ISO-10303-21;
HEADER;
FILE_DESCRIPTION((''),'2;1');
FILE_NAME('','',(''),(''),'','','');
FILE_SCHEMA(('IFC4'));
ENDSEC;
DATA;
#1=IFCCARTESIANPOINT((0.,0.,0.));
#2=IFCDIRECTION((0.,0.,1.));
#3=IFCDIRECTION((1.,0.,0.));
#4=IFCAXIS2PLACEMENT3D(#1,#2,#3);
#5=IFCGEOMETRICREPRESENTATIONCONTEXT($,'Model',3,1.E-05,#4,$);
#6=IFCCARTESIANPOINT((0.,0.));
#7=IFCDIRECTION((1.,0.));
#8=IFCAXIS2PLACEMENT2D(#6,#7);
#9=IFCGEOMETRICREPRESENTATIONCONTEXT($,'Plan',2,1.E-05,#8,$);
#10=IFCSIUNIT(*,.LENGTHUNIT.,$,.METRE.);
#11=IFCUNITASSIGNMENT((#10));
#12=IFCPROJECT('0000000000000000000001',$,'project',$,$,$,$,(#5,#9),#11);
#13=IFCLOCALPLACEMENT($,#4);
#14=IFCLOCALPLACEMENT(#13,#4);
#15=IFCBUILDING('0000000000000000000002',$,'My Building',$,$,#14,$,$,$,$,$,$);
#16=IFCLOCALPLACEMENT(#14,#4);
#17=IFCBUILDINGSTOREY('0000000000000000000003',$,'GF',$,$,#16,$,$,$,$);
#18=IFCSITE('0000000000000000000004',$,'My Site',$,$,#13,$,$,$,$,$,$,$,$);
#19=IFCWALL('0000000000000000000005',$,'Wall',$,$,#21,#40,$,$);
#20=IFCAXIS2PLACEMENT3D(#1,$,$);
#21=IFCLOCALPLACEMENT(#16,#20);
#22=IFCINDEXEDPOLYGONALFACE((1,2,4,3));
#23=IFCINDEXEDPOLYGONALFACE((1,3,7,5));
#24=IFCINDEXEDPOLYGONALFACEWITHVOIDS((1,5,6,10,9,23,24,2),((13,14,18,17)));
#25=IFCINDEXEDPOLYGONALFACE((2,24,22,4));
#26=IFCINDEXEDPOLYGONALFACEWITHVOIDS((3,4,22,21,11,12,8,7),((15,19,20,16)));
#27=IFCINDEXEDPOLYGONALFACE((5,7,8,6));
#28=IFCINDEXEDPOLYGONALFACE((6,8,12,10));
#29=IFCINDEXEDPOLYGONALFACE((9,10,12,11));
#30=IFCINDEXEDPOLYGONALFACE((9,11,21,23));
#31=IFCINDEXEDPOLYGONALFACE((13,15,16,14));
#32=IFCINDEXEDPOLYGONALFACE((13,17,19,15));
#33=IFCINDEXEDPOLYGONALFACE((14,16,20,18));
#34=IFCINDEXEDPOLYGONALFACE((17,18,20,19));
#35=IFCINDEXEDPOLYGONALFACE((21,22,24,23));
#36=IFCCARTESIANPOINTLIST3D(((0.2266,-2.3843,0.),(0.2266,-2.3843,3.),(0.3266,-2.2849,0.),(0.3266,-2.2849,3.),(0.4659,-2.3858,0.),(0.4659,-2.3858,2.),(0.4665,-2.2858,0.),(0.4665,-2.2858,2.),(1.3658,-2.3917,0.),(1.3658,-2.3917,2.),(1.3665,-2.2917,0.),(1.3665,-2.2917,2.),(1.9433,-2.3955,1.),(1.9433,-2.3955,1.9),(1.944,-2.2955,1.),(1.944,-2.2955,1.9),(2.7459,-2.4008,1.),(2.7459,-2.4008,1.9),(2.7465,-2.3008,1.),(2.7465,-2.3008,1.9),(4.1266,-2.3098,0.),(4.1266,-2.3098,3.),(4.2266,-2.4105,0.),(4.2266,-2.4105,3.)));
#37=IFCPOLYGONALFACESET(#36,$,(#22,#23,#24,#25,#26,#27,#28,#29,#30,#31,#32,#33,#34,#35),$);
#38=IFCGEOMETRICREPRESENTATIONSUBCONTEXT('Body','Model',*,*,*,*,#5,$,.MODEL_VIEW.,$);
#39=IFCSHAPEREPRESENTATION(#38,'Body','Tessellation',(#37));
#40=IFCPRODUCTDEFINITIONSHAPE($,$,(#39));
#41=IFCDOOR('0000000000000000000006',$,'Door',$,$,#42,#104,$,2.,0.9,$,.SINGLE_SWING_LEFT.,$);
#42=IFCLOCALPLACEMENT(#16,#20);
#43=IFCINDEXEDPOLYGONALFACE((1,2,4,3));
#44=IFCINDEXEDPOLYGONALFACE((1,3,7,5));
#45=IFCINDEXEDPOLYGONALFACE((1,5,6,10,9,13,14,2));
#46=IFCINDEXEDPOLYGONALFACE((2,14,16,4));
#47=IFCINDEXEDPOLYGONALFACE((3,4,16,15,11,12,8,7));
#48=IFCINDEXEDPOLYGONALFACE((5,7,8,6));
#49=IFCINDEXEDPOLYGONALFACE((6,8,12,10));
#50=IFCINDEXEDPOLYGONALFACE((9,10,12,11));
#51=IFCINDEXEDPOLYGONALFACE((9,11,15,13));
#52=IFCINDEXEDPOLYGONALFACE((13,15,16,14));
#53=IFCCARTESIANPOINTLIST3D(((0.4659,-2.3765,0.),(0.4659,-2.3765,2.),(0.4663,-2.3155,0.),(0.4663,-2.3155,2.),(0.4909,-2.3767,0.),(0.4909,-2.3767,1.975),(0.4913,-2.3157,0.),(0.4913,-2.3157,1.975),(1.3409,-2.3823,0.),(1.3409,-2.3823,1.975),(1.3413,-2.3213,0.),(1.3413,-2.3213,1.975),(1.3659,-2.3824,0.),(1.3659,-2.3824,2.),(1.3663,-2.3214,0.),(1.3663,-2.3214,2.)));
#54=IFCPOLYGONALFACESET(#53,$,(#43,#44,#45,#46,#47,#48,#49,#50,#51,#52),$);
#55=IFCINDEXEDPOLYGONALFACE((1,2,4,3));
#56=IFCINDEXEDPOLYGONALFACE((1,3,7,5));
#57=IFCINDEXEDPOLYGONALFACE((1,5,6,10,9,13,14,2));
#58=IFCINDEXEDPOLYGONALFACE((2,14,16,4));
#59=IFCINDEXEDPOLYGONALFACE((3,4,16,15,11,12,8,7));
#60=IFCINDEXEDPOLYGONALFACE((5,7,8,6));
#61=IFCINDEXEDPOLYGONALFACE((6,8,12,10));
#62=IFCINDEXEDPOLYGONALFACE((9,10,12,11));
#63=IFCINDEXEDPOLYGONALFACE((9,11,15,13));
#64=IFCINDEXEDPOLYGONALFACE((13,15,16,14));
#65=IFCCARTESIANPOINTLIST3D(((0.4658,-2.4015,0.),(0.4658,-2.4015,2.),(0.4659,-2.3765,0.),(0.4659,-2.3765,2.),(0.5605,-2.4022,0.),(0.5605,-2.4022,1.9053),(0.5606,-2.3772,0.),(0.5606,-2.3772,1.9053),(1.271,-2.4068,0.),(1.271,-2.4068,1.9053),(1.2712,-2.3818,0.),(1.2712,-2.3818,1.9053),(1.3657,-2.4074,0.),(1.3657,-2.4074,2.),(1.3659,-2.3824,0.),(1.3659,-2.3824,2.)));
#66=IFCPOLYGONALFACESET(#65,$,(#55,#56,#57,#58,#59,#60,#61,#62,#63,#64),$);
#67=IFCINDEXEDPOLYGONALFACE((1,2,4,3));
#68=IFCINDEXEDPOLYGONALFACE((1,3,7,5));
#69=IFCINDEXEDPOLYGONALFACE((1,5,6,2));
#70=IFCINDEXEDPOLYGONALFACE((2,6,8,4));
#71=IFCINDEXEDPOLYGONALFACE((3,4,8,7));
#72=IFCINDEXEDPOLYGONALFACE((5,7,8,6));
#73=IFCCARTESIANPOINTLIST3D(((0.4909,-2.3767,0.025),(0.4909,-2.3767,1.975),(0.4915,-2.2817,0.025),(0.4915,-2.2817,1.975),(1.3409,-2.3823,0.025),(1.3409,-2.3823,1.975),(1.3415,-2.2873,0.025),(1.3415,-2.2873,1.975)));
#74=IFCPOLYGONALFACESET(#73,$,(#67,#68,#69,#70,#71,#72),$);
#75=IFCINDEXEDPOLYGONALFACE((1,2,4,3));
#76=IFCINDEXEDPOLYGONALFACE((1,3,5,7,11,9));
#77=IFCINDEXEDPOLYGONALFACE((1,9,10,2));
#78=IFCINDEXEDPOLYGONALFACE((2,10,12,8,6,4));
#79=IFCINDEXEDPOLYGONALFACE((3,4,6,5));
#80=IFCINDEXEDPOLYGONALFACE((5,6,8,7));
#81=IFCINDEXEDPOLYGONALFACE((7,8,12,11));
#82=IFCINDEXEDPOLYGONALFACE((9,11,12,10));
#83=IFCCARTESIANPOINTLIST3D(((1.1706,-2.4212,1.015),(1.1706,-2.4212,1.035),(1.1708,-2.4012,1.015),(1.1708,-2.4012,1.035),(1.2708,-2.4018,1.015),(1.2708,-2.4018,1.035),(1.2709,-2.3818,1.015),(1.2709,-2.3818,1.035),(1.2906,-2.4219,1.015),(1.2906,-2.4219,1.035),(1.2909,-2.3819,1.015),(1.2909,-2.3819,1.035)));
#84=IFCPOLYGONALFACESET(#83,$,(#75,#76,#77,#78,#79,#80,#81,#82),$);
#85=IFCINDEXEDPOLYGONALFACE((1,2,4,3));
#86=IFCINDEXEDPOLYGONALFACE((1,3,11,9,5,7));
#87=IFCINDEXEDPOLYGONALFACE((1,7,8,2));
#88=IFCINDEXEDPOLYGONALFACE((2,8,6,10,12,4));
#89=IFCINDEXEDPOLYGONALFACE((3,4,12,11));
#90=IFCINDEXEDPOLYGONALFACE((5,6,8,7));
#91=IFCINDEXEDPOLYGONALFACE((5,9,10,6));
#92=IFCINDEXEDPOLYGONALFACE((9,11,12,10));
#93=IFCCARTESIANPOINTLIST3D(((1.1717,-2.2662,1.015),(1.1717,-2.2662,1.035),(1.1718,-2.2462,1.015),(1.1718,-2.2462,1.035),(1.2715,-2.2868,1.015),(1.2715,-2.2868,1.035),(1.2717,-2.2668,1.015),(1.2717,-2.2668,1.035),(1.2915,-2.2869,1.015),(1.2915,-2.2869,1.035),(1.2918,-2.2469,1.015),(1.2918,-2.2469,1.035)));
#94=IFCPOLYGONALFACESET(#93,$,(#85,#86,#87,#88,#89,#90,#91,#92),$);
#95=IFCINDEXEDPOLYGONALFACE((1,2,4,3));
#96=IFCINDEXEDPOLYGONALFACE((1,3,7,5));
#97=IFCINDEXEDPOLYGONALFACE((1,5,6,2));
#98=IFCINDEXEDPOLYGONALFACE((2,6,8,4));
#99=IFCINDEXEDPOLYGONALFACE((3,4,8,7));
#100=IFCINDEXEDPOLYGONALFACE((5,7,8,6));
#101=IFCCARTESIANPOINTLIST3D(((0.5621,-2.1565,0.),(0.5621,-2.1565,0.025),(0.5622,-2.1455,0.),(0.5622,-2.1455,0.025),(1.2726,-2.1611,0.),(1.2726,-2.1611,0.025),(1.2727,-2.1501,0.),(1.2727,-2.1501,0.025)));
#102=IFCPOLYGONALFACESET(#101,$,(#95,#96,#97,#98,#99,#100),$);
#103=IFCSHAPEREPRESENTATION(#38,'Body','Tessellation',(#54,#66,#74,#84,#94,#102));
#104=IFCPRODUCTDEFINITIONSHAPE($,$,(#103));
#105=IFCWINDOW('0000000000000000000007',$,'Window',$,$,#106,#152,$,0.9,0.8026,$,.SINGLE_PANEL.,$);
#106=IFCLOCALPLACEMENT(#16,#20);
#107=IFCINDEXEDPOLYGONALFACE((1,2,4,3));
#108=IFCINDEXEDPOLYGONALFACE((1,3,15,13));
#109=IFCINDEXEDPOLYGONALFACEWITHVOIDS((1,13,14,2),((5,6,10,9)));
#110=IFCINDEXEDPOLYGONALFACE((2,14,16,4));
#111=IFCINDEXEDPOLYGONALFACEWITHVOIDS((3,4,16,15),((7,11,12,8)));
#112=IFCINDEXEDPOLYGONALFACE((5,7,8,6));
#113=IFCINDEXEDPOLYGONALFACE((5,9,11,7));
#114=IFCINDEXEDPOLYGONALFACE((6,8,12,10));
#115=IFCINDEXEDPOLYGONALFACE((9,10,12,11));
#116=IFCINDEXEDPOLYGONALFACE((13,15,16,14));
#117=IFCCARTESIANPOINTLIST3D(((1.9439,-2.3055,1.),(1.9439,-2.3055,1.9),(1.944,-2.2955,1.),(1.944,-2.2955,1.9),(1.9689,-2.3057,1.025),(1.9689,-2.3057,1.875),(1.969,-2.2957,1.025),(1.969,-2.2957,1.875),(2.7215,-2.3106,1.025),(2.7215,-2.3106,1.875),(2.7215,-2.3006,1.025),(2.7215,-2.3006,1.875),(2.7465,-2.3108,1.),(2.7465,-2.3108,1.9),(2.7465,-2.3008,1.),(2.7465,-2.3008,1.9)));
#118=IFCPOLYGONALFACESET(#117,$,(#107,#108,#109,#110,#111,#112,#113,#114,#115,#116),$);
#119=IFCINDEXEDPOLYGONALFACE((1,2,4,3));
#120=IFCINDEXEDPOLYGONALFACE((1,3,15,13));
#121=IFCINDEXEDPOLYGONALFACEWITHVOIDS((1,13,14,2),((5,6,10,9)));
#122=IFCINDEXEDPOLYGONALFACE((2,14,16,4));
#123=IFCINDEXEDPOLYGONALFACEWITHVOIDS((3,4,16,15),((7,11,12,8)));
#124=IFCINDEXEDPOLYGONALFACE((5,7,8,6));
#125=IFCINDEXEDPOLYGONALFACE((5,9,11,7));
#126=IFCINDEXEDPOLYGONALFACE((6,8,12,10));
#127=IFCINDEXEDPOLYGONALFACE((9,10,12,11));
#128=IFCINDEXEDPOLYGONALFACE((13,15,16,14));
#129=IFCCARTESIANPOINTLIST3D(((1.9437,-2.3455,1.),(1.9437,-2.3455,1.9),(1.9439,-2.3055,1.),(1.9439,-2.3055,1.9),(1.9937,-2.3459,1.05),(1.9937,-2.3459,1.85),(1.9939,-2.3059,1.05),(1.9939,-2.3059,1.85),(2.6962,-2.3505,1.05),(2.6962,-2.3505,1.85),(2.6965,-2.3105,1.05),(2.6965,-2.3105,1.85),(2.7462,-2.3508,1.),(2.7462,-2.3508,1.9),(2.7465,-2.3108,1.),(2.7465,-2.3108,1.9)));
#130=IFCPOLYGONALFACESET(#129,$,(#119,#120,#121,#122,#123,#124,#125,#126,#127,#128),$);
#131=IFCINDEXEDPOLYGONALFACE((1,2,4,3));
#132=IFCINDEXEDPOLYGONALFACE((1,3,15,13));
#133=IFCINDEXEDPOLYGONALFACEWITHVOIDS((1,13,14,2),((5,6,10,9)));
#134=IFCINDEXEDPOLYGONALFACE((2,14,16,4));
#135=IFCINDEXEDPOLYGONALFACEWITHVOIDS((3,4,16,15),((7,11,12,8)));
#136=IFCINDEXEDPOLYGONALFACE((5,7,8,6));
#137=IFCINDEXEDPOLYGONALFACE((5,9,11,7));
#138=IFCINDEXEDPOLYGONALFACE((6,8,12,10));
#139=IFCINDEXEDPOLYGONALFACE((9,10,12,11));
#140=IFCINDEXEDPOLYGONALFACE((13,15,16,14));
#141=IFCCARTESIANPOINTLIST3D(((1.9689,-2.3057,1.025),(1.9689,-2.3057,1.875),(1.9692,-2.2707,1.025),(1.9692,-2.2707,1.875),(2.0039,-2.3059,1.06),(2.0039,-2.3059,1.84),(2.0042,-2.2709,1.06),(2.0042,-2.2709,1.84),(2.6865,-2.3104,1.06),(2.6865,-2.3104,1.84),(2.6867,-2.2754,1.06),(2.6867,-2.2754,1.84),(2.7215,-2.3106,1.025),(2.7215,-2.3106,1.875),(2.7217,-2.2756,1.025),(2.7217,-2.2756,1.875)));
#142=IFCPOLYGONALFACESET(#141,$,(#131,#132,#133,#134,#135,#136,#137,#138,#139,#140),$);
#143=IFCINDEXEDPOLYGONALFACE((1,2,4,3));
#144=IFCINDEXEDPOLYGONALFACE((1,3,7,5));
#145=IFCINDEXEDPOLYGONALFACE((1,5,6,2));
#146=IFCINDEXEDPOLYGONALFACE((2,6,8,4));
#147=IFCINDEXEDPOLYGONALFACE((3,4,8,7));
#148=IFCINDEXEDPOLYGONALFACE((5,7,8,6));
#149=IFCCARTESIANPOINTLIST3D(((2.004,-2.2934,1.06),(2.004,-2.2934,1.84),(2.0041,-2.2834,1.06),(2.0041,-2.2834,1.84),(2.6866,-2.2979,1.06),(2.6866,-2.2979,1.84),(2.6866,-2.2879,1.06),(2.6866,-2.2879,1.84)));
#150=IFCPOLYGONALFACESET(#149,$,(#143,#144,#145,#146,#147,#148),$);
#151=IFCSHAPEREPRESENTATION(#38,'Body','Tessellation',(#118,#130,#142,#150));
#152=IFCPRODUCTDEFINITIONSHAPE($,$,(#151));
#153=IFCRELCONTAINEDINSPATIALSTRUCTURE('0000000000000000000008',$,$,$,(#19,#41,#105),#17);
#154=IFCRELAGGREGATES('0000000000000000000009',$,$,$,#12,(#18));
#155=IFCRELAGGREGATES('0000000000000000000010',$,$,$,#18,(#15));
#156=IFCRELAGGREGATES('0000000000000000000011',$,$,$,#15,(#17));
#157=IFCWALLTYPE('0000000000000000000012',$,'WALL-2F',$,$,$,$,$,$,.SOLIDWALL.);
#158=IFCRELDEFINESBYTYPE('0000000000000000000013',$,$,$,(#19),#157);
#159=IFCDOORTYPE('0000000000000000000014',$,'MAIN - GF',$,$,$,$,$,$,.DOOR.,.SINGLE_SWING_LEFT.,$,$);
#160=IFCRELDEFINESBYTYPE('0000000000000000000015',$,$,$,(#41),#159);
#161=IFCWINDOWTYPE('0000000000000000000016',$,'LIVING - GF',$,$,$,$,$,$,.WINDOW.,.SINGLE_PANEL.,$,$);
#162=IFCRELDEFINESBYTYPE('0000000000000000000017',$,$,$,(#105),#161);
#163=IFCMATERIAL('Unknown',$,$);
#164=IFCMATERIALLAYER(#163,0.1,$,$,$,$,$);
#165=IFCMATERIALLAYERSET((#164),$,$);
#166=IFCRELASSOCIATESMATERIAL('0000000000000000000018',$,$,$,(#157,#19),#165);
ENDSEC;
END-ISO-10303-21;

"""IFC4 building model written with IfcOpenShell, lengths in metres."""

from ifc_helpers import new_model, entity, si_unit, frame, origin_with_axes, origin_2d_with_axis, place, context, subcontext, project, spatial, line, indexed_curve, outline, extrude, shape, source, transform, mapped, material, layer, layer_set, layer_usage, type_object, type_shapes, element, fill, save


model = new_model("IFC4")

# Units and contexts
model_context = context("Model", 3, precision=1e-05, world=origin_with_axes())
plan_context = context("Plan", 2, precision=1e-05, world=origin_2d_with_axis())
body_context_1 = subcontext(model_context, "Body", "Model", "MODEL_VIEW")
body_context_2 = subcontext(plan_context, "Body", "Plan", "PLAN_VIEW")
ifc_project = project(units=[si_unit("LENGTHUNIT", "METRE")], contexts=[model_context, plan_context])

# Site, building, storey
site_placement = place(None, origin_with_axes())
site = spatial("IfcSite", under=ifc_project, at=site_placement, Name="My Site")
building_placement = place(site_placement, origin_with_axes())
building = spatial("IfcBuilding", under=site, at=building_placement, Name="My Building")
storey_placement = place(building_placement, origin_with_axes())
storey = spatial("IfcBuildingStorey", under=building, at=storey_placement, Name="GF")

# Shared definitions
ifc_material = material(Name="Unknown")

# Shared definitions
ifc_layer_1 = layer(ifc_material, 0.1)
ifc_layer_set_1 = layer_set([ifc_layer_1])
wall_type_1 = type_object("IfcWallType", Name="WALL-2F", PredefinedType="SOLIDWALL", material=ifc_layer_set_1)

# Wall, openings, door, window
ifc_layer_usage_1 = layer_usage(ifc_layer_set_1, "AXIS2", "POSITIVE", 0.0)
wall_1_placement = place(storey_placement, frame((0.2266, -2.3843, 0.0), z_axis=(0.0, 0.0, 1.0), x_axis=(0.999979, -0.006552, 0.0)))
wall_1 = element("IfcWall", 1, at=wall_1_placement, inside=storey, type_object=wall_type_1, material=ifc_layer_usage_1, Name="Wall", context=body_context_1, shape_type="SweptSolid", body=[
    extrude(outline(indexed_curve([(0.0, 0.0), (0.0993, 0.1), (3.8994, 0.1), (4.0001, 0.0)], segments=[line(1, 2, 3, 4, 1)])), origin_with_axes(), (0.0, 0.0, 1.0), 3.0),
])
shared_shape_1 = source(origin_with_axes(), body_context_1, "Body", "SweptSolid", [
    extrude(outline(indexed_curve([(0.0, 0.0), (0.9, 0.0), (0.9, 2.0), (0.0, 2.0)], segments=[line(1, 2, 3, 4, 1)])), frame((0.0, -0.6, 0.0), z_axis=(0.0, -1.0, 0.0), x_axis=(1.0, 0.0, 0.0)), (0.0, 0.0, -1.0), 1.2),
])
opening_1_placement = place(wall_1_placement, frame((0.2393, 0.0, 0.0), z_axis=(0.0, 0.0, 1.0), x_axis=(1.0, 0.0, 0.0)))
opening_1 = element("IfcOpeningElement", 2, at=opening_1_placement, cuts=wall_1, PredefinedType="OPENING", context=body_context_1, shape_type="MappedRepresentation", body=[
    mapped(shared_shape_1, transform((0.0, 0.0, 0.0), x_axis=(1.0, 0.0, 0.0), y_axis=(0.0, 1.0, 0.0), z_axis=(0.0, 0.0, 1.0), scale=1.0)),
])
shared_shape_2 = source(origin_with_axes(), body_context_1, "Body", "SweptSolid", [
    extrude(outline(indexed_curve([(0.0, 0.0), (0.8026, 0.0), (0.8026, 0.9), (0.0, 0.9)], segments=[line(1, 2, 3, 4, 1)])), frame((0.0, -0.6, 0.0), z_axis=(0.0, -1.0, 0.0), x_axis=(1.0, 0.0, 0.0)), (0.0, 0.0, -1.0), 1.2),
])
opening_2_placement = place(wall_1_placement, frame((1.7168, 0.0, 1.0), z_axis=(0.0, 0.0, 1.0), x_axis=(1.0, 0.0, 0.0)))
opening_2 = element("IfcOpeningElement", 3, at=opening_2_placement, cuts=wall_1, PredefinedType="OPENING", context=body_context_1, shape_type="MappedRepresentation", body=[
    mapped(shared_shape_2, transform((0.0, 0.0, 0.0), x_axis=(1.0, 0.0, 0.0), y_axis=(0.0, 1.0, 0.0), z_axis=(0.0, 0.0, 1.0), scale=1.0)),
])
door_type_1 = type_object("IfcDoorType", Name="MAIN - GF", OperationType="SINGLE_SWING_LEFT", PredefinedType="DOOR")
shared_shape_3 = source(origin_with_axes(), body_context_1, "Body", "SweptSolid", [
    extrude(outline(indexed_curve([(0.0, 0.0), (0.0, 2.0), (0.9, 2.0), (0.9, 0.0), (0.875, 0.0), (0.875, 1.975), (0.025, 1.975), (0.025, 0.0)], segments=[line(1, 2, 3, 4, 5, 6, 7, 8, 1)])), frame((0.0, 0.0093, 0.0), z_axis=(0.0, -1.0, 0.0), x_axis=(1.0, 0.0, 0.0)), (0.0, 0.0, -1.0), 0.061),
    extrude(outline(indexed_curve([(0.0, 0.0), (0.0, 2.0), (0.9, 2.0), (0.9, 0.0), (0.8053, 0.0), (0.8053, 1.9053), (0.0947, 1.9053), (0.0947, 0.0)], segments=[line(1, 2, 3, 4, 5, 6, 7, 8, 1)])), frame((0.0, -0.0157, 0.0), z_axis=(0.0, -1.0, 0.0), x_axis=(1.0, 0.0, 0.0)), (0.0, 0.0, -1.0), 0.025),
    extrude(outline(indexed_curve([(0.0, 0.0), (0.85, 0.0), (0.85, 0.095), (0.0, 0.095)], segments=[line(1, 2, 3, 4, 1)])), frame((0.025, 0.0093, 0.025), z_axis=(0.0, 0.0, 1.0), x_axis=(1.0, 0.0, 0.0)), (0.0, 0.0, 1.0), 1.95),
    extrude(outline(indexed_curve([(0.0, 0.0), (0.0, -0.04), (-0.12, -0.04), (-0.12, -0.02), (-0.02, -0.02), (-0.02, 0.0)], segments=[line(1, 2, 3, 4, 5, 6, 1)])), frame((0.825, 0.0093, 1.015), z_axis=(0.0, 0.0, 1.0), x_axis=(1.0, 0.0, 0.0)), (0.0, 0.0, 1.0), 0.02),
    extrude(outline(indexed_curve([(0.0, 0.0), (0.0, 0.04), (-0.12, 0.04), (-0.12, 0.02), (-0.02, 0.02), (-0.02, 0.0)], segments=[line(1, 2, 3, 4, 5, 6, 1)])), frame((0.825, 0.1043, 1.015), z_axis=(0.0, 0.0, 1.0), x_axis=(1.0, 0.0, 0.0)), (0.0, 0.0, 1.0), 0.02),
    extrude(outline(indexed_curve([(0.0, 0.0), (0.7105, 0.0), (0.7105, 0.011), (0.0, 0.011)], segments=[line(1, 2, 3, 4, 1)])), frame((0.0947, 0.23, 0.0), z_axis=(0.0, 0.0, 1.0), x_axis=(1.0, 0.0, 0.0)), (0.0, 0.0, 1.0), 0.025),
])
shared_shape_4 = source(origin_with_axes(), body_context_2, "Body", "Curve2D", [
    entity("IfcIndexedPolyCurve", entity("IfcCartesianPointList2D", [[0.0, -0.0157], [0.0, 0.0703], [0.025, 0.0703], [0.025, 0.0093], [0.0947, 0.0093], [0.0947, -0.0157]]), [entity("IfcLineIndex", [1, 2, 3, 4, 5, 6, 1])]),
    entity("IfcIndexedPolyCurve", entity("IfcCartesianPointList2D", [[0.9, -0.0157], [0.9, 0.0703], [0.875, 0.0703], [0.875, 0.0093], [0.8053, 0.0093], [0.8053, -0.0157]]), [entity("IfcLineIndex", [1, 2, 3, 4, 5, 6, 1])]),
    entity("IfcTrimmedCurve", entity("IfcEllipse", entity("IfcAxis2Placement2D", entity("IfcCartesianPoint", [0.12, 0.0703]), entity("IfcDirection", [1.0, 0.0])), 0.755, 0.85), [entity("IfcCartesianPoint", [0.875, 0.0703])], [entity("IfcCartesianPoint", [0.12, 0.9203])], True, "CARTESIAN"),
    entity("IfcIndexedPolyCurve", entity("IfcCartesianPointList2D", [[0.025, 0.0703], [0.12, 0.0703], [0.12, 0.9203], [0.025, 0.9203]]), [entity("IfcLineIndex", [1, 2, 3, 4, 1])]),
])
type_shapes(door_type_1, [shared_shape_3, shared_shape_4])
door_1_placement = place(opening_1_placement, frame((0.0, 0.0, 0.0), z_axis=(0.0, 0.0, 1.0), x_axis=(1.0, 0.0, 0.0)))
door_1 = element("IfcDoor", 4, at=door_1_placement, inside=storey, type_object=door_type_1, Name="Door", OperationType="SINGLE_SWING_LEFT", OverallHeight=2.0, OverallWidth=0.9, shapes=[
    shape(body_context_1, "Body", "MappedRepresentation", [mapped(shared_shape_3, transform((0.0, 0.0, 0.0), x_axis=(1.0, 0.0, 0.0), y_axis=(0.0, 1.0, 0.0), z_axis=(0.0, 0.0, 1.0), scale=1.0))]),
    shape(body_context_2, "Body", "MappedRepresentation", [mapped(shared_shape_4, transform((0.0, 0.0, 0.0), x_axis=(1.0, 0.0, 0.0), y_axis=(0.0, 1.0, 0.0), z_axis=(0.0, 0.0, 1.0), scale=1.0))]),
])
fill(opening_1, door_1)
window_type_1 = type_object("IfcWindowType", Name="LIVING - GF", PartitioningType="SINGLE_PANEL", PredefinedType="WINDOW")
shared_shape_5 = source(origin_with_axes(), body_context_1, "Body", "SweptSolid", [
    extrude(outline(indexed_curve([(0.0, 0.0), (0.8026, 0.0), (0.8026, 0.9), (0.0, 0.9)], segments=[line(1, 2, 3, 4, 1)]), holes=[indexed_curve([(0.025, 0.025), (0.7776, 0.025), (0.7776, 0.875), (0.025, 0.875)], segments=[line(1, 2, 3, 4, 1)])]), frame((0.0, 0.09, 0.0), z_axis=(0.0, -1.0, 0.0), x_axis=(1.0, 0.0, 0.0)), (0.0, 0.0, -1.0), 0.01),
    extrude(outline(indexed_curve([(0.0, 0.0), (0.8026, 0.0), (0.8026, 0.9), (0.0, 0.9)], segments=[line(1, 2, 3, 4, 1)]), holes=[indexed_curve([(0.05, 0.05), (0.7526, 0.05), (0.7526, 0.85), (0.05, 0.85)], segments=[line(1, 2, 3, 4, 1)])]), frame((0.0, 0.05, 0.0), z_axis=(0.0, -1.0, 0.0), x_axis=(1.0, 0.0, 0.0)), (0.0, 0.0, -1.0), 0.04),
    extrude(outline(indexed_curve([(0.0, 0.0), (0.7526, 0.0), (0.7526, 0.85), (0.0, 0.85)], segments=[line(1, 2, 3, 4, 1)]), holes=[indexed_curve([(0.035, 0.035), (0.7176, 0.035), (0.7176, 0.815), (0.035, 0.815)], segments=[line(1, 2, 3, 4, 1)])]), frame((0.025, 0.09, 0.025), z_axis=(0.0, -1.0, 0.0), x_axis=(1.0, 0.0, 0.0)), (0.0, 0.0, -1.0), 0.035),
    extrude(outline(indexed_curve([(0.035, 0.035), (0.7176, 0.035), (0.7176, 0.815), (0.035, 0.815)], segments=[line(1, 2, 3, 4, 1)])), frame((0.025, 0.1025, 0.025), z_axis=(0.0, -1.0, 0.0), x_axis=(1.0, 0.0, 0.0)), (0.0, 0.0, -1.0), 0.01),
])
shared_shape_6 = source(origin_with_axes(), body_context_2, "Body", "Curve2D", [
    entity("IfcIndexedPolyCurve", entity("IfcCartesianPointList2D", [[0.05, 0.05], [0.7526, 0.05]])),
    entity("IfcIndexedPolyCurve", entity("IfcCartesianPointList2D", [[0.0, 0.1], [0.025, 0.1], [0.025, 0.09], [0.05, 0.09], [0.05, 0.05], [0.0, 0.05]]), [entity("IfcLineIndex", [1, 2, 3, 4, 5, 6, 1])]),
    entity("IfcIndexedPolyCurve", entity("IfcCartesianPointList2D", [[0.8026, 0.1], [0.7776, 0.1], [0.7776, 0.09], [0.7526, 0.09], [0.7526, 0.05], [0.8026, 0.05]]), [entity("IfcLineIndex", [1, 2, 3, 4, 5, 6, 1])]),
    entity("IfcIndexedPolyCurve", entity("IfcCartesianPointList2D", [[0.025, 0.09], [0.06, 0.09], [0.06, 0.125], [0.025, 0.125]]), [entity("IfcLineIndex", [1, 2, 3, 4, 1])]),
    entity("IfcIndexedPolyCurve", entity("IfcCartesianPointList2D", [[0.7776, 0.09], [0.7426, 0.09], [0.7426, 0.125], [0.7776, 0.125]]), [entity("IfcLineIndex", [1, 2, 3, 4, 1])]),
    entity("IfcIndexedPolyCurve", entity("IfcCartesianPointList2D", [[0.06, 0.09], [0.7426, 0.09]])),
    entity("IfcIndexedPolyCurve", entity("IfcCartesianPointList2D", [[0.06, 0.125], [0.7426, 0.125]])),
    entity("IfcIndexedPolyCurve", entity("IfcCartesianPointList2D", [[0.06, 0.1075], [0.7426, 0.1075]])),
])
type_shapes(window_type_1, [shared_shape_5, shared_shape_6])
window_1_placement = place(opening_2_placement, frame((0.0, 0.0, 0.0), z_axis=(0.0, 0.0, 1.0), x_axis=(1.0, 0.0, 0.0)))
window_1 = element("IfcWindow", 5, at=window_1_placement, inside=storey, type_object=window_type_1, Name="Window", OverallHeight=0.9, OverallWidth=0.8026, PartitioningType="SINGLE_PANEL", shapes=[
    shape(body_context_1, "Body", "MappedRepresentation", [mapped(shared_shape_5, transform((0.0, 0.0, 0.0), x_axis=(1.0, 0.0, 0.0), y_axis=(0.0, 1.0, 0.0), z_axis=(0.0, 0.0, 1.0), scale=1.0))]),
    shape(body_context_2, "Body", "MappedRepresentation", [mapped(shared_shape_6, transform((0.0, 0.0, 0.0), x_axis=(1.0, 0.0, 0.0), y_axis=(0.0, 1.0, 0.0), z_axis=(0.0, 0.0, 1.0), scale=1.0))]),
])
fill(opening_2, window_1)

save(model, "model.ifc")
